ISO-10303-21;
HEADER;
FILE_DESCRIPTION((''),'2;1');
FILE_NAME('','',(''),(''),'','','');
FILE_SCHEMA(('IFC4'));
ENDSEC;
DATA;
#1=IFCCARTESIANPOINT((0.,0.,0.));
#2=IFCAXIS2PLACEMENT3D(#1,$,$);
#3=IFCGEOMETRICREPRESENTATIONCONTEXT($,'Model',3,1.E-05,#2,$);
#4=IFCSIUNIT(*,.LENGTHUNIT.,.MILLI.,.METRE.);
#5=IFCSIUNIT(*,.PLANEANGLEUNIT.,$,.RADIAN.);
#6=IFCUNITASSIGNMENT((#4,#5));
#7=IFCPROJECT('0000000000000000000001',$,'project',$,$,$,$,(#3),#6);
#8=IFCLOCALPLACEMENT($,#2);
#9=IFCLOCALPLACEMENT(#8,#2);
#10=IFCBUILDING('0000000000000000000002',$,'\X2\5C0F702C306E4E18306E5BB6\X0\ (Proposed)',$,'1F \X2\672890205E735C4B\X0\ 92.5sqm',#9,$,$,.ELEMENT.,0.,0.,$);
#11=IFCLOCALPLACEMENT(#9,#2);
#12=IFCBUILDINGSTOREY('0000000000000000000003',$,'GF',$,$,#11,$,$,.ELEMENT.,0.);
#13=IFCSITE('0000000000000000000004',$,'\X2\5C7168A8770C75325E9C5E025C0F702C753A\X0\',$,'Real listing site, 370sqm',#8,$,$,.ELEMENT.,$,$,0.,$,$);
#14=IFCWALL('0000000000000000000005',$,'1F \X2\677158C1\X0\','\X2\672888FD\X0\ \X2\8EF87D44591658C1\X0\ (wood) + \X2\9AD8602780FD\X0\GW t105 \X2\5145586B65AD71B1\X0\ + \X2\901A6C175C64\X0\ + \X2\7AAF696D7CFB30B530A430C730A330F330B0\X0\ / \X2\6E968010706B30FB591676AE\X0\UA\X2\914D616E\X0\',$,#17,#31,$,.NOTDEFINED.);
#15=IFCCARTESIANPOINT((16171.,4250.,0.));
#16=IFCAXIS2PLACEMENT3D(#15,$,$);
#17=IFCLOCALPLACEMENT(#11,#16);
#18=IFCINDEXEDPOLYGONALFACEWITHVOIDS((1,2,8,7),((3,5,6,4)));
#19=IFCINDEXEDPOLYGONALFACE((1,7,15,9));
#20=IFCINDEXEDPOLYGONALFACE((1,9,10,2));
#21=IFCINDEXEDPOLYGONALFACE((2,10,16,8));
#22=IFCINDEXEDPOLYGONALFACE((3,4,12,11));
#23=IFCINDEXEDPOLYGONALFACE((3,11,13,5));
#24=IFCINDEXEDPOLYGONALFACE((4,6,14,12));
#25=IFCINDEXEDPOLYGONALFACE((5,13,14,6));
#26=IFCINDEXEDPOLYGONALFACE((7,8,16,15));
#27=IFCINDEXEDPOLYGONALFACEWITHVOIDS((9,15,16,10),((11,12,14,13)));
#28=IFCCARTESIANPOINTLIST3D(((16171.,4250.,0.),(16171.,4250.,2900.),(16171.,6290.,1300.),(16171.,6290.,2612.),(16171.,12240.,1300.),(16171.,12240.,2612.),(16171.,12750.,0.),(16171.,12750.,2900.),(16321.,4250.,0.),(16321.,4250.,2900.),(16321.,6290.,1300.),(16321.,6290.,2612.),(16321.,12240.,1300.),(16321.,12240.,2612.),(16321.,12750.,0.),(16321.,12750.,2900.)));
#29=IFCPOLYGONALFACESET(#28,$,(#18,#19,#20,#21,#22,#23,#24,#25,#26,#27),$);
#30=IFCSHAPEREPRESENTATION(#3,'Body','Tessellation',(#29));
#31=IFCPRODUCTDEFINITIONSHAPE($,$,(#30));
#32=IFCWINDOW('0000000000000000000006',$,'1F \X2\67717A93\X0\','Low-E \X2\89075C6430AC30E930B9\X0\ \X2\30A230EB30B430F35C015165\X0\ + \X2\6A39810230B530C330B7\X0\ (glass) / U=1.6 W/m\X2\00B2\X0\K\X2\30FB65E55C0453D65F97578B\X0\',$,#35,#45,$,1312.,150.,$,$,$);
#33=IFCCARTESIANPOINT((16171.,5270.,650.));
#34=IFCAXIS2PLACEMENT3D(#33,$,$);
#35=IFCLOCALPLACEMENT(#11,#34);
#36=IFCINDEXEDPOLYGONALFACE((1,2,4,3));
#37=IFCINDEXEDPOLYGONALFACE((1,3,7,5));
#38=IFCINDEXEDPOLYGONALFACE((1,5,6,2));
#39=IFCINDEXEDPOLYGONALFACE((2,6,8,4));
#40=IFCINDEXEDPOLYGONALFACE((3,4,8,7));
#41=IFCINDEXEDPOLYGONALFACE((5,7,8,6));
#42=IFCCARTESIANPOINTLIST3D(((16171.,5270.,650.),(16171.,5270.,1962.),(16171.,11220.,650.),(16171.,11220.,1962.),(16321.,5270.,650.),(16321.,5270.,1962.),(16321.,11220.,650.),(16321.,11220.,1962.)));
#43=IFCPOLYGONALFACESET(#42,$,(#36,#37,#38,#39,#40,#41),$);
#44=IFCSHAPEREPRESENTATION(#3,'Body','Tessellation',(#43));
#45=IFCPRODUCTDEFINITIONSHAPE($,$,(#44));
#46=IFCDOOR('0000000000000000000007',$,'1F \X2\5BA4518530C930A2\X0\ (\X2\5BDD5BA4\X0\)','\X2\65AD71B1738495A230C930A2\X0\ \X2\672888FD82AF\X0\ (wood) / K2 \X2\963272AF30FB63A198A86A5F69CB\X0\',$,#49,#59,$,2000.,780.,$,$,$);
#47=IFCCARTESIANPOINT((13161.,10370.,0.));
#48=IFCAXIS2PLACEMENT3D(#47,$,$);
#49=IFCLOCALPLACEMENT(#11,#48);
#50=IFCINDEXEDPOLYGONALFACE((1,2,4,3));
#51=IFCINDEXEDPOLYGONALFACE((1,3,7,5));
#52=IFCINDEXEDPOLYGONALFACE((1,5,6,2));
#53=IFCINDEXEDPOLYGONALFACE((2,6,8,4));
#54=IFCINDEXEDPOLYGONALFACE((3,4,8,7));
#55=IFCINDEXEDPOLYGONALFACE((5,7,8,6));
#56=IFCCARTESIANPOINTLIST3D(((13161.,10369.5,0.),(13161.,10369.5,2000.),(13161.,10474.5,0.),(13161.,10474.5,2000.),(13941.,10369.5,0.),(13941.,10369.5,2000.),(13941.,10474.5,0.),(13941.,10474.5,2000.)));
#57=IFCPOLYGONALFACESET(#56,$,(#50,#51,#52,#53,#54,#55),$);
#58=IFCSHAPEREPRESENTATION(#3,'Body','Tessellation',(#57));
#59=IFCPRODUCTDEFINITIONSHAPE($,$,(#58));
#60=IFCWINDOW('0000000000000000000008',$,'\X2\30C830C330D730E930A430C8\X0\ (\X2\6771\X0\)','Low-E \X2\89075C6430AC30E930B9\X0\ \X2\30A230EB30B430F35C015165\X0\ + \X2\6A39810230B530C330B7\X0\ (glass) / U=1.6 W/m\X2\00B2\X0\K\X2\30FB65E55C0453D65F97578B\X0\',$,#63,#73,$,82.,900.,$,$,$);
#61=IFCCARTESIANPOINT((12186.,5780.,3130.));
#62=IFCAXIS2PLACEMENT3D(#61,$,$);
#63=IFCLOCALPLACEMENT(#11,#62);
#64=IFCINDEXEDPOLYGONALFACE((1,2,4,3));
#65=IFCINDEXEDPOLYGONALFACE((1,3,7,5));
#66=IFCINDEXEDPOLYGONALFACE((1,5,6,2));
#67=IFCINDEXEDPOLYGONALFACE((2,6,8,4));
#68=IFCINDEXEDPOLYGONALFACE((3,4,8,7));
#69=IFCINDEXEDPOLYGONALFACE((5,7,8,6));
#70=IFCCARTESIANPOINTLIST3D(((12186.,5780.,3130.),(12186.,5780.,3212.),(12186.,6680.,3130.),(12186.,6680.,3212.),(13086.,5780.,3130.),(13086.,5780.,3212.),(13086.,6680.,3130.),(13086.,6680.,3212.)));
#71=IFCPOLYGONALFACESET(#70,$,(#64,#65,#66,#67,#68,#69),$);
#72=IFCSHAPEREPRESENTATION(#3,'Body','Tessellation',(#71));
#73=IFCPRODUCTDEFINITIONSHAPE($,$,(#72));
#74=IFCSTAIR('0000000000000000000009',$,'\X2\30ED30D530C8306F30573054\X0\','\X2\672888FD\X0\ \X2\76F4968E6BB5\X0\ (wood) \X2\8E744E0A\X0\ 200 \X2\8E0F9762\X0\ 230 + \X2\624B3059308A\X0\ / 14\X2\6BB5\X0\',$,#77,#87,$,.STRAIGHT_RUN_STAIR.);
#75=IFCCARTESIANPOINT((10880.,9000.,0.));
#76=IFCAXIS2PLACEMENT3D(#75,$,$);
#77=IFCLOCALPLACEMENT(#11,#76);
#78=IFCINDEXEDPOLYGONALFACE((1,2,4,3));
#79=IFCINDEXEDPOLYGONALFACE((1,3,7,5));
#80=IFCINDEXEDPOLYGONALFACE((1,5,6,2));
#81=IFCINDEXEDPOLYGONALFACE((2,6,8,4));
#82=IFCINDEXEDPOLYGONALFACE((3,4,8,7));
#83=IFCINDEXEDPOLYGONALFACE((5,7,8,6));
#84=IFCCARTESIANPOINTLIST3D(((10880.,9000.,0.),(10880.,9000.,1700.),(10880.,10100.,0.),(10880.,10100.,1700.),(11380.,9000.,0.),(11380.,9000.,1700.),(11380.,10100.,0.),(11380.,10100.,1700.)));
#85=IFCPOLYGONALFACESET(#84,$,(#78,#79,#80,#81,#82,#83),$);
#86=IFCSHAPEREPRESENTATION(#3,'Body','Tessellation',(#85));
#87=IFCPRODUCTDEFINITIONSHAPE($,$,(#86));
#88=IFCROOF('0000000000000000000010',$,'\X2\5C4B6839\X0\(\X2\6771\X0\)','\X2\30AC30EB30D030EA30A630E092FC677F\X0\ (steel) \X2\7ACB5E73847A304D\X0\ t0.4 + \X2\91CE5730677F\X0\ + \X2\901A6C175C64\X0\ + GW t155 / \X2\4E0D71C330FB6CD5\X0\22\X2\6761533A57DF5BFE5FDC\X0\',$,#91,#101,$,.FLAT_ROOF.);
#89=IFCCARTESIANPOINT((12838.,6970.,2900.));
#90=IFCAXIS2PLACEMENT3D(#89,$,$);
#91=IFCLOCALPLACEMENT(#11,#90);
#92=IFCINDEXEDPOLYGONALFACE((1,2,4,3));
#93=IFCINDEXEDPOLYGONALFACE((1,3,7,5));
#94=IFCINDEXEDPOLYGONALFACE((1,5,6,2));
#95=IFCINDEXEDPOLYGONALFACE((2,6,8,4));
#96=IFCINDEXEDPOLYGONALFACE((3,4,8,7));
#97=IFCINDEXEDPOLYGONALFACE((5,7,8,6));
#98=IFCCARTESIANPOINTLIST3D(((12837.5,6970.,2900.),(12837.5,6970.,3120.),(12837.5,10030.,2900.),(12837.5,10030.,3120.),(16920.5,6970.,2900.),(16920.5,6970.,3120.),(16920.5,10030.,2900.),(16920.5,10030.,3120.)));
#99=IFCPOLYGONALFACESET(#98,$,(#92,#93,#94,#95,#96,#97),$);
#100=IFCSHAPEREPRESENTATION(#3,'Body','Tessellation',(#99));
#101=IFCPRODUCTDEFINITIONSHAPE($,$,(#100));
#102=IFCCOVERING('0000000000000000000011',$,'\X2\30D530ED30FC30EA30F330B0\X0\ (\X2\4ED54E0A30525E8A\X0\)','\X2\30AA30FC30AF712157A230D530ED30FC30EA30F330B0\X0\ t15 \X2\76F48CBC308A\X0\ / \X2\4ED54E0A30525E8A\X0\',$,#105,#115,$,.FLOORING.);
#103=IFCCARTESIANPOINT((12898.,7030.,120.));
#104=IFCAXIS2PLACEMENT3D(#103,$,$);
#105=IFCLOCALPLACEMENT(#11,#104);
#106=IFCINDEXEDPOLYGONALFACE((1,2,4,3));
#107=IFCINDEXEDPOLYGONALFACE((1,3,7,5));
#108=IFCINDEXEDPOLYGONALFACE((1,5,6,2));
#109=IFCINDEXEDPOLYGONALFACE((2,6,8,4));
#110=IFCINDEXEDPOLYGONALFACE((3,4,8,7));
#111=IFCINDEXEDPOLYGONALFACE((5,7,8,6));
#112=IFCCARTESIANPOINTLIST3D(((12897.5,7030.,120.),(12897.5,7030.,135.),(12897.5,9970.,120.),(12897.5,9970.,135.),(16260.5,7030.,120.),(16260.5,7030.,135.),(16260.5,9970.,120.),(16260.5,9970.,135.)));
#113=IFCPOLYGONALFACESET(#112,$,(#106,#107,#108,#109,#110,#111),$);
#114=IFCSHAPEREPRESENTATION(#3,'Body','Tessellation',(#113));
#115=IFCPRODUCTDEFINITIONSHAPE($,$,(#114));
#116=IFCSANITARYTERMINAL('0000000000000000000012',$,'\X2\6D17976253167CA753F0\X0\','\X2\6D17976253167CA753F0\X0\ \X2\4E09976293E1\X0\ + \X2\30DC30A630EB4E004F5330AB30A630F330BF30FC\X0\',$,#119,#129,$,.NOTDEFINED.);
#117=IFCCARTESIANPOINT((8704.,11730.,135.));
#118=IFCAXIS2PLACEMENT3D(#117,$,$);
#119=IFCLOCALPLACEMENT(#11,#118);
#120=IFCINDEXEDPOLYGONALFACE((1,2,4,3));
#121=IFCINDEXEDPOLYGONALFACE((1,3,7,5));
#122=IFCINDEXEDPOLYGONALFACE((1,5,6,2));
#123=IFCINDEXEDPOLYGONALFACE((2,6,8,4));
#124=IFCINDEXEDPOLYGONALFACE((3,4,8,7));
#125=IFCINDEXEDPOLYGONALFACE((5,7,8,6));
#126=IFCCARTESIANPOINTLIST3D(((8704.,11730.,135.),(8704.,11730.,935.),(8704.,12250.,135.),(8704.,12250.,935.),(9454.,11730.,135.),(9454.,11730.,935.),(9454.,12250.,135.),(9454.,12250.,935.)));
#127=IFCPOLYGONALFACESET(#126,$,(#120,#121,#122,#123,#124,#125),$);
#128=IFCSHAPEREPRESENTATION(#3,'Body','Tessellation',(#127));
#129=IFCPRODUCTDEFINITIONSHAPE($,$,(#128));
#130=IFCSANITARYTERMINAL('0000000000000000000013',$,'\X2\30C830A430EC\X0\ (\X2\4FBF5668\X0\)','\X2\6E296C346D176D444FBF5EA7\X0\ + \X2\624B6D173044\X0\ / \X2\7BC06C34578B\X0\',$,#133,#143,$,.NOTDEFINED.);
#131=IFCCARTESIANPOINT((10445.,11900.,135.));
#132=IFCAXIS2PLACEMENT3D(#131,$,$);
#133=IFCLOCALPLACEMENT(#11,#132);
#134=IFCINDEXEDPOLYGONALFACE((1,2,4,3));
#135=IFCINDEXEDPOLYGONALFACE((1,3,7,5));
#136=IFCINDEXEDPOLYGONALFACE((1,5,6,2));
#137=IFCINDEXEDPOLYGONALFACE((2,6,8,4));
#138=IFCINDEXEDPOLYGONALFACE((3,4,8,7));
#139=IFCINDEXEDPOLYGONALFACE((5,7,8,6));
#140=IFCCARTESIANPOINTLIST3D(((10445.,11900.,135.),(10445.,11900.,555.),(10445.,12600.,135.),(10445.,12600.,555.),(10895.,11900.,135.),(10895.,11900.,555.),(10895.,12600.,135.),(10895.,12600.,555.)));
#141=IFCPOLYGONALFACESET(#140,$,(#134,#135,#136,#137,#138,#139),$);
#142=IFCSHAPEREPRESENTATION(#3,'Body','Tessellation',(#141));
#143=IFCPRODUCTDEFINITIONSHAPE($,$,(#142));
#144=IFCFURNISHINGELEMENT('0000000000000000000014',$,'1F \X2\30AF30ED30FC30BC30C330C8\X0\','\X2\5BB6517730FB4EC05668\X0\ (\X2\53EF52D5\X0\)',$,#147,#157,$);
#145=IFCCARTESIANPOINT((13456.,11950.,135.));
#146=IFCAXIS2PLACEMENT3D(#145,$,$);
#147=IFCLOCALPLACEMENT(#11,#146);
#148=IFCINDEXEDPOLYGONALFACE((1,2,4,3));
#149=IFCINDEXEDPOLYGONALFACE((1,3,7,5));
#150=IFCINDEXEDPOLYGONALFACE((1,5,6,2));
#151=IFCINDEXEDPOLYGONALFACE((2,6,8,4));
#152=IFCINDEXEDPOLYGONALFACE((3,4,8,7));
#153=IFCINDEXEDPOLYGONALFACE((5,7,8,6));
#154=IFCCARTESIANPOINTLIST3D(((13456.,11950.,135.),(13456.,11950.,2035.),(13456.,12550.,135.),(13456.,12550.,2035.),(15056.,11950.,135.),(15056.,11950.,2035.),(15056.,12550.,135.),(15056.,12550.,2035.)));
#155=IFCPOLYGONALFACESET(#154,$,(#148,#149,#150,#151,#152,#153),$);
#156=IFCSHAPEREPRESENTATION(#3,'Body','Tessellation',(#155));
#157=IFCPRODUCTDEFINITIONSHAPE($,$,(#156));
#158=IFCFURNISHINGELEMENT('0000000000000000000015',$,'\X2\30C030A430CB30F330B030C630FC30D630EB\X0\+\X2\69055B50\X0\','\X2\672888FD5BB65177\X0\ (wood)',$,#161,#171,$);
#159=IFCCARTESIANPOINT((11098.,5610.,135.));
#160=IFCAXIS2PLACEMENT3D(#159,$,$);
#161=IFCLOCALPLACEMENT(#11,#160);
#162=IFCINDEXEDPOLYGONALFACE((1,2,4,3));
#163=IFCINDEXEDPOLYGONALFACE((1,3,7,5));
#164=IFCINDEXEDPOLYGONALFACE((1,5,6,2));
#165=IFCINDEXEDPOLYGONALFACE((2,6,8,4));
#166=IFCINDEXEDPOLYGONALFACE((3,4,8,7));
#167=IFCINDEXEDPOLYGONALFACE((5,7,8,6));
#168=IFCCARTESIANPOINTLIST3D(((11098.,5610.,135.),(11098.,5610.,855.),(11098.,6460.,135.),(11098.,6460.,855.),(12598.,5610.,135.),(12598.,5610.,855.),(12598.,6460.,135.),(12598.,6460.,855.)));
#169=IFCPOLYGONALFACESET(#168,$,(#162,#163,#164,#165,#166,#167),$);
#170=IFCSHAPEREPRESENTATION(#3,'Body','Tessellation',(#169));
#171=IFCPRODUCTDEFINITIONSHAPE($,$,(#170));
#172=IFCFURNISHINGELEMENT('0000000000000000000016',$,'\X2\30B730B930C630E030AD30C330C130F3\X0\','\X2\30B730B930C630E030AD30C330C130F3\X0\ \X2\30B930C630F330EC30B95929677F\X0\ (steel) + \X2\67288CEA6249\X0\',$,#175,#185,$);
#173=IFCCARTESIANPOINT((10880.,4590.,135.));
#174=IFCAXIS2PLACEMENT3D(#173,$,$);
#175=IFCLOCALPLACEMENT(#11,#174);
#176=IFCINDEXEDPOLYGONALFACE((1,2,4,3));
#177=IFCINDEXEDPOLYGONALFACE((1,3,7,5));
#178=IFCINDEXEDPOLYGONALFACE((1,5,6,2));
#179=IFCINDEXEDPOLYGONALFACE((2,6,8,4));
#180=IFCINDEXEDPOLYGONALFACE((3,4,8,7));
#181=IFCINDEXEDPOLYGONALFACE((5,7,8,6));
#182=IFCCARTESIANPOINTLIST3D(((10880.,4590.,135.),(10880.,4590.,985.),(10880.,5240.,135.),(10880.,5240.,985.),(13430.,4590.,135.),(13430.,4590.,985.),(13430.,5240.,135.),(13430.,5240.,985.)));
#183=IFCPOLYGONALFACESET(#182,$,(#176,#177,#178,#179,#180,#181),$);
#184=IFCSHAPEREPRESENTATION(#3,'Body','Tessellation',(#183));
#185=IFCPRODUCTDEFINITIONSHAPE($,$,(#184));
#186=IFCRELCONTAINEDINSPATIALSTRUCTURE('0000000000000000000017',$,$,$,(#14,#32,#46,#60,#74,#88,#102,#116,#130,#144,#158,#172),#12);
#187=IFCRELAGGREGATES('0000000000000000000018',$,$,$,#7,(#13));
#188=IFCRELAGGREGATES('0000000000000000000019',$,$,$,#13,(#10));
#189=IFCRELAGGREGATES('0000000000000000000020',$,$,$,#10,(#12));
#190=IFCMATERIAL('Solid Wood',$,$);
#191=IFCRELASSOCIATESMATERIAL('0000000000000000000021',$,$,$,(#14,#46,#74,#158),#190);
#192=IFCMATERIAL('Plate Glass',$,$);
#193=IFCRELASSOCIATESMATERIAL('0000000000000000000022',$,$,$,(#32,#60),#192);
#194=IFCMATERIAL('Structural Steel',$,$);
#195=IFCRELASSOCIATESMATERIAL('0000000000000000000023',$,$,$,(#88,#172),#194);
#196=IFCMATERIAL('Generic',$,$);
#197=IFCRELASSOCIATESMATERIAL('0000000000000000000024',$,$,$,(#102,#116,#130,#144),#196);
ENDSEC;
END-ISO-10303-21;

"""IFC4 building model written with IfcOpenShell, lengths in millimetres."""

from ifc_helpers import new_model, si_unit, frame, frame_2d, origin, place, context, project, spatial, rectangle, extrude, material, element, fill, save


model = new_model("IFC4")

# Units and contexts
model_context = context("Model", 3, precision=1e-05, world=origin())
ifc_project = project(units=[si_unit("LENGTHUNIT", "METRE", prefix="MILLI"), si_unit("PLANEANGLEUNIT", "RADIAN")], contexts=[model_context])

# Site, building, storey
site_placement = place(None, origin())
site = spatial("IfcSite", under=ifc_project, at=site_placement, Name="山梨県甲府市小瀬町", ObjectType="Real listing site, 370sqm", CompositionType="ELEMENT", RefElevation=0.0)
building_placement = place(site_placement, origin())
building = spatial("IfcBuilding", under=site, at=building_placement, Name="小瀬の丘の家 (Proposed)", ObjectType="1F 木造平屋 92.5sqm", CompositionType="ELEMENT", ElevationOfRefHeight=0.0, ElevationOfTerrain=0.0)
storey_placement = place(building_placement, origin())
storey = spatial("IfcBuildingStorey", under=building, at=storey_placement, Name="GF", CompositionType="ELEMENT", Elevation=0.0)

# Shared definitions
ifc_material_1 = material(Name="Solid Wood")

# Wall, opening, window
wall_1_placement = place(storey_placement, frame((16171.0, 4250.0, 0.0)))
wall_1 = element("IfcWall", 1, at=wall_1_placement, inside=storey, material=ifc_material_1, Name="1F 東壁", Description="木製 軸組外壁 (wood) + 高性能GW t105 充填断熱 + 通気層 + 窯業系サイディング / 準耐火・外皮UA配慮", PredefinedType="NOTDEFINED", context=model_context, shape_type="SweptSolid", body=[
    extrude(rectangle(XDim=150.0, YDim=8500.0, at=frame_2d((75.0, 4250.0))), frame((16171.0, 4250.0, 0.0)), (0.0, 0.0, 1.0), 2900.0),
])
opening_1_placement = place(storey_placement, frame((16171.0, 5270.0, 650.0)))
opening_1 = element("IfcOpeningElement", 2, at=opening_1_placement, cuts=wall_1, PredefinedType="NOTDEFINED", context=model_context, shape_type="SweptSolid", body=[
    extrude(rectangle(XDim=150.0, YDim=5950.0, at=frame_2d((75.0, 2975.0))), frame((16171.0, 5270.0, 650.0)), (0.0, 0.0, 1.0), 1312.0),
])
ifc_material_2 = material(Name="Plate Glass")
window_1_placement = place(storey_placement, frame((16171.0, 5270.0, 650.0)))
window_1 = element("IfcWindow", 3, at=window_1_placement, inside=storey, material=ifc_material_2, Name="1F 東窓", Description="Low-E 複層ガラス アルゴン封入 + 樹脂サッシ (glass) / U=1.6 W/m²K・日射取得型", OverallHeight=1312.0, OverallWidth=150.0, context=model_context, shape_type="SweptSolid", body=[
    extrude(rectangle(XDim=150.0, YDim=5950.0, at=frame_2d((75.0, 2975.0))), frame((16171.0, 5270.0, 650.0)), (0.0, 0.0, 1.0), 1312.0),
])
fill(opening_1, window_1)

# Door
door_placement = place(storey_placement, frame((13161.0, 10370.0, 0.0)))
element("IfcDoor", 4, at=door_placement, inside=storey, material=ifc_material_1, Name="1F 室内ドア (寝室)", Description="断熱玄関ドア 木製芯 (wood) / K2 防犯・採風機構", OverallHeight=2000.0, OverallWidth=780.0, context=model_context, shape_type="SweptSolid", body=[
    extrude(rectangle(XDim=780.0, YDim=105.0, at=frame_2d((390.0, 52.0))), frame((13161.0, 10370.0, 0.0)), (0.0, 0.0, 1.0), 2000.0),
])

# Window
window_2_placement = place(storey_placement, frame((12186.0, 5780.0, 3130.0)))
element("IfcWindow", 5, at=window_2_placement, inside=storey, material=ifc_material_2, Name="トップライト (東)", Description="Low-E 複層ガラス アルゴン封入 + 樹脂サッシ (glass) / U=1.6 W/m²K・日射取得型", OverallHeight=82.0, OverallWidth=900.0, context=model_context, shape_type="SweptSolid", body=[
    extrude(rectangle(XDim=900.0, YDim=900.0, at=frame_2d((450.0, 450.0))), frame((12186.0, 5780.0, 3130.0)), (0.0, 0.0, 1.0), 82.0),
])

# Stair
stair_placement = place(storey_placement, frame((10880.0, 9000.0, 0.0)))
element("IfcStair", 6, at=stair_placement, inside=storey, material=ifc_material_1, Name="ロフトはしご", Description="木製 直階段 (wood) 蹴上 200 踏面 230 + 手すり / 14段", PredefinedType="STRAIGHT_RUN_STAIR", context=model_context, shape_type="SweptSolid", body=[
    extrude(rectangle(XDim=500.0, YDim=1100.0, at=frame_2d((250.0, 550.0))), frame((10880.0, 9000.0, 0.0)), (0.0, 0.0, 1.0), 1700.0),
])

# Roof
ifc_material_3 = material(Name="Structural Steel")
roof_placement = place(storey_placement, frame((12838.0, 6970.0, 2900.0)))
element("IfcRoof", 7, at=roof_placement, inside=storey, material=ifc_material_3, Name="屋根(東)", Description="ガルバリウム鋼板 (steel) 立平葺き t0.4 + 野地板 + 通気層 + GW t155 / 不燃・法22条区域対応", PredefinedType="FLAT_ROOF", context=model_context, shape_type="SweptSolid", body=[
    extrude(rectangle(XDim=4083.0, YDim=3060.0, at=frame_2d((2041.0, 1530.0))), frame((12838.0, 6970.0, 2900.0)), (0.0, 0.0, 1.0), 220.0),
])

# Covering
ifc_material_4 = material(Name="Generic")
covering_placement = place(storey_placement, frame((12898.0, 7030.0, 120.0)))
element("IfcCovering", 8, at=covering_placement, inside=storey, material=ifc_material_4, Name="フローリング (仕上げ床)", Description="オーク無垢フローリング t15 直貼り / 仕上げ床", PredefinedType="FLOORING", context=model_context, shape_type="SweptSolid", body=[
    extrude(rectangle(XDim=3363.0, YDim=2940.0, at=frame_2d((1681.0, 1470.0))), frame((12898.0, 7030.0, 120.0)), (0.0, 0.0, 1.0), 15.0),
])

# Sanitary terminals
sanitary_terminal_1_placement = place(storey_placement, frame((8704.0, 11730.0, 135.0)))
element("IfcSanitaryTerminal", 9, at=sanitary_terminal_1_placement, inside=storey, material=ifc_material_4, Name="洗面化粧台", Description="洗面化粧台 三面鏡 + ボウル一体カウンター", PredefinedType="NOTDEFINED", context=model_context, shape_type="SweptSolid", body=[
    extrude(rectangle(XDim=750.0, YDim=520.0, at=frame_2d((375.0, 260.0))), frame((8704.0, 11730.0, 135.0)), (0.0, 0.0, 1.0), 800.0),
])
sanitary_terminal_2_placement = place(storey_placement, frame((10445.0, 11900.0, 135.0)))
element("IfcSanitaryTerminal", 10, at=sanitary_terminal_2_placement, inside=storey, material=ifc_material_4, Name="トイレ (便器)", Description="温水洗浄便座 + 手洗い / 節水型", PredefinedType="NOTDEFINED", context=model_context, shape_type="SweptSolid", body=[
    extrude(rectangle(XDim=450.0, YDim=700.0, at=frame_2d((225.0, 350.0))), frame((10445.0, 11900.0, 135.0)), (0.0, 0.0, 1.0), 420.0),
])

# Furnishing elements
furnishing_1_placement = place(storey_placement, frame((13456.0, 11950.0, 135.0)))
element("IfcFurnishingElement", 11, at=furnishing_1_placement, inside=storey, material=ifc_material_4, Name="1F クローゼット", Description="家具・什器 (可動)", context=model_context, shape_type="SweptSolid", body=[
    extrude(rectangle(XDim=1600.0, YDim=600.0, at=frame_2d((800.0, 300.0))), frame((13456.0, 11950.0, 135.0)), (0.0, 0.0, 1.0), 1900.0),
])
furnishing_2_placement = place(storey_placement, frame((11098.0, 5610.0, 135.0)))
element("IfcFurnishingElement", 12, at=furnishing_2_placement, inside=storey, material=ifc_material_1, Name="ダイニングテーブル+椅子", Description="木製家具 (wood)", context=model_context, shape_type="SweptSolid", body=[
    extrude(rectangle(XDim=1500.0, YDim=850.0, at=frame_2d((750.0, 425.0))), frame((11098.0, 5610.0, 135.0)), (0.0, 0.0, 1.0), 720.0),
])
furnishing_3_placement = place(storey_placement, frame((10880.0, 4590.0, 135.0)))
element("IfcFurnishingElement", 13, at=furnishing_3_placement, inside=storey, material=ifc_material_3, Name="システムキッチン", Description="システムキッチン ステンレス天板 (steel) + 木質扉", context=model_context, shape_type="SweptSolid", body=[
    extrude(rectangle(XDim=2550.0, YDim=650.0, at=frame_2d((1275.0, 325.0))), frame((10880.0, 4590.0, 135.0)), (0.0, 0.0, 1.0), 850.0),
])

save(model, "model.ifc")
